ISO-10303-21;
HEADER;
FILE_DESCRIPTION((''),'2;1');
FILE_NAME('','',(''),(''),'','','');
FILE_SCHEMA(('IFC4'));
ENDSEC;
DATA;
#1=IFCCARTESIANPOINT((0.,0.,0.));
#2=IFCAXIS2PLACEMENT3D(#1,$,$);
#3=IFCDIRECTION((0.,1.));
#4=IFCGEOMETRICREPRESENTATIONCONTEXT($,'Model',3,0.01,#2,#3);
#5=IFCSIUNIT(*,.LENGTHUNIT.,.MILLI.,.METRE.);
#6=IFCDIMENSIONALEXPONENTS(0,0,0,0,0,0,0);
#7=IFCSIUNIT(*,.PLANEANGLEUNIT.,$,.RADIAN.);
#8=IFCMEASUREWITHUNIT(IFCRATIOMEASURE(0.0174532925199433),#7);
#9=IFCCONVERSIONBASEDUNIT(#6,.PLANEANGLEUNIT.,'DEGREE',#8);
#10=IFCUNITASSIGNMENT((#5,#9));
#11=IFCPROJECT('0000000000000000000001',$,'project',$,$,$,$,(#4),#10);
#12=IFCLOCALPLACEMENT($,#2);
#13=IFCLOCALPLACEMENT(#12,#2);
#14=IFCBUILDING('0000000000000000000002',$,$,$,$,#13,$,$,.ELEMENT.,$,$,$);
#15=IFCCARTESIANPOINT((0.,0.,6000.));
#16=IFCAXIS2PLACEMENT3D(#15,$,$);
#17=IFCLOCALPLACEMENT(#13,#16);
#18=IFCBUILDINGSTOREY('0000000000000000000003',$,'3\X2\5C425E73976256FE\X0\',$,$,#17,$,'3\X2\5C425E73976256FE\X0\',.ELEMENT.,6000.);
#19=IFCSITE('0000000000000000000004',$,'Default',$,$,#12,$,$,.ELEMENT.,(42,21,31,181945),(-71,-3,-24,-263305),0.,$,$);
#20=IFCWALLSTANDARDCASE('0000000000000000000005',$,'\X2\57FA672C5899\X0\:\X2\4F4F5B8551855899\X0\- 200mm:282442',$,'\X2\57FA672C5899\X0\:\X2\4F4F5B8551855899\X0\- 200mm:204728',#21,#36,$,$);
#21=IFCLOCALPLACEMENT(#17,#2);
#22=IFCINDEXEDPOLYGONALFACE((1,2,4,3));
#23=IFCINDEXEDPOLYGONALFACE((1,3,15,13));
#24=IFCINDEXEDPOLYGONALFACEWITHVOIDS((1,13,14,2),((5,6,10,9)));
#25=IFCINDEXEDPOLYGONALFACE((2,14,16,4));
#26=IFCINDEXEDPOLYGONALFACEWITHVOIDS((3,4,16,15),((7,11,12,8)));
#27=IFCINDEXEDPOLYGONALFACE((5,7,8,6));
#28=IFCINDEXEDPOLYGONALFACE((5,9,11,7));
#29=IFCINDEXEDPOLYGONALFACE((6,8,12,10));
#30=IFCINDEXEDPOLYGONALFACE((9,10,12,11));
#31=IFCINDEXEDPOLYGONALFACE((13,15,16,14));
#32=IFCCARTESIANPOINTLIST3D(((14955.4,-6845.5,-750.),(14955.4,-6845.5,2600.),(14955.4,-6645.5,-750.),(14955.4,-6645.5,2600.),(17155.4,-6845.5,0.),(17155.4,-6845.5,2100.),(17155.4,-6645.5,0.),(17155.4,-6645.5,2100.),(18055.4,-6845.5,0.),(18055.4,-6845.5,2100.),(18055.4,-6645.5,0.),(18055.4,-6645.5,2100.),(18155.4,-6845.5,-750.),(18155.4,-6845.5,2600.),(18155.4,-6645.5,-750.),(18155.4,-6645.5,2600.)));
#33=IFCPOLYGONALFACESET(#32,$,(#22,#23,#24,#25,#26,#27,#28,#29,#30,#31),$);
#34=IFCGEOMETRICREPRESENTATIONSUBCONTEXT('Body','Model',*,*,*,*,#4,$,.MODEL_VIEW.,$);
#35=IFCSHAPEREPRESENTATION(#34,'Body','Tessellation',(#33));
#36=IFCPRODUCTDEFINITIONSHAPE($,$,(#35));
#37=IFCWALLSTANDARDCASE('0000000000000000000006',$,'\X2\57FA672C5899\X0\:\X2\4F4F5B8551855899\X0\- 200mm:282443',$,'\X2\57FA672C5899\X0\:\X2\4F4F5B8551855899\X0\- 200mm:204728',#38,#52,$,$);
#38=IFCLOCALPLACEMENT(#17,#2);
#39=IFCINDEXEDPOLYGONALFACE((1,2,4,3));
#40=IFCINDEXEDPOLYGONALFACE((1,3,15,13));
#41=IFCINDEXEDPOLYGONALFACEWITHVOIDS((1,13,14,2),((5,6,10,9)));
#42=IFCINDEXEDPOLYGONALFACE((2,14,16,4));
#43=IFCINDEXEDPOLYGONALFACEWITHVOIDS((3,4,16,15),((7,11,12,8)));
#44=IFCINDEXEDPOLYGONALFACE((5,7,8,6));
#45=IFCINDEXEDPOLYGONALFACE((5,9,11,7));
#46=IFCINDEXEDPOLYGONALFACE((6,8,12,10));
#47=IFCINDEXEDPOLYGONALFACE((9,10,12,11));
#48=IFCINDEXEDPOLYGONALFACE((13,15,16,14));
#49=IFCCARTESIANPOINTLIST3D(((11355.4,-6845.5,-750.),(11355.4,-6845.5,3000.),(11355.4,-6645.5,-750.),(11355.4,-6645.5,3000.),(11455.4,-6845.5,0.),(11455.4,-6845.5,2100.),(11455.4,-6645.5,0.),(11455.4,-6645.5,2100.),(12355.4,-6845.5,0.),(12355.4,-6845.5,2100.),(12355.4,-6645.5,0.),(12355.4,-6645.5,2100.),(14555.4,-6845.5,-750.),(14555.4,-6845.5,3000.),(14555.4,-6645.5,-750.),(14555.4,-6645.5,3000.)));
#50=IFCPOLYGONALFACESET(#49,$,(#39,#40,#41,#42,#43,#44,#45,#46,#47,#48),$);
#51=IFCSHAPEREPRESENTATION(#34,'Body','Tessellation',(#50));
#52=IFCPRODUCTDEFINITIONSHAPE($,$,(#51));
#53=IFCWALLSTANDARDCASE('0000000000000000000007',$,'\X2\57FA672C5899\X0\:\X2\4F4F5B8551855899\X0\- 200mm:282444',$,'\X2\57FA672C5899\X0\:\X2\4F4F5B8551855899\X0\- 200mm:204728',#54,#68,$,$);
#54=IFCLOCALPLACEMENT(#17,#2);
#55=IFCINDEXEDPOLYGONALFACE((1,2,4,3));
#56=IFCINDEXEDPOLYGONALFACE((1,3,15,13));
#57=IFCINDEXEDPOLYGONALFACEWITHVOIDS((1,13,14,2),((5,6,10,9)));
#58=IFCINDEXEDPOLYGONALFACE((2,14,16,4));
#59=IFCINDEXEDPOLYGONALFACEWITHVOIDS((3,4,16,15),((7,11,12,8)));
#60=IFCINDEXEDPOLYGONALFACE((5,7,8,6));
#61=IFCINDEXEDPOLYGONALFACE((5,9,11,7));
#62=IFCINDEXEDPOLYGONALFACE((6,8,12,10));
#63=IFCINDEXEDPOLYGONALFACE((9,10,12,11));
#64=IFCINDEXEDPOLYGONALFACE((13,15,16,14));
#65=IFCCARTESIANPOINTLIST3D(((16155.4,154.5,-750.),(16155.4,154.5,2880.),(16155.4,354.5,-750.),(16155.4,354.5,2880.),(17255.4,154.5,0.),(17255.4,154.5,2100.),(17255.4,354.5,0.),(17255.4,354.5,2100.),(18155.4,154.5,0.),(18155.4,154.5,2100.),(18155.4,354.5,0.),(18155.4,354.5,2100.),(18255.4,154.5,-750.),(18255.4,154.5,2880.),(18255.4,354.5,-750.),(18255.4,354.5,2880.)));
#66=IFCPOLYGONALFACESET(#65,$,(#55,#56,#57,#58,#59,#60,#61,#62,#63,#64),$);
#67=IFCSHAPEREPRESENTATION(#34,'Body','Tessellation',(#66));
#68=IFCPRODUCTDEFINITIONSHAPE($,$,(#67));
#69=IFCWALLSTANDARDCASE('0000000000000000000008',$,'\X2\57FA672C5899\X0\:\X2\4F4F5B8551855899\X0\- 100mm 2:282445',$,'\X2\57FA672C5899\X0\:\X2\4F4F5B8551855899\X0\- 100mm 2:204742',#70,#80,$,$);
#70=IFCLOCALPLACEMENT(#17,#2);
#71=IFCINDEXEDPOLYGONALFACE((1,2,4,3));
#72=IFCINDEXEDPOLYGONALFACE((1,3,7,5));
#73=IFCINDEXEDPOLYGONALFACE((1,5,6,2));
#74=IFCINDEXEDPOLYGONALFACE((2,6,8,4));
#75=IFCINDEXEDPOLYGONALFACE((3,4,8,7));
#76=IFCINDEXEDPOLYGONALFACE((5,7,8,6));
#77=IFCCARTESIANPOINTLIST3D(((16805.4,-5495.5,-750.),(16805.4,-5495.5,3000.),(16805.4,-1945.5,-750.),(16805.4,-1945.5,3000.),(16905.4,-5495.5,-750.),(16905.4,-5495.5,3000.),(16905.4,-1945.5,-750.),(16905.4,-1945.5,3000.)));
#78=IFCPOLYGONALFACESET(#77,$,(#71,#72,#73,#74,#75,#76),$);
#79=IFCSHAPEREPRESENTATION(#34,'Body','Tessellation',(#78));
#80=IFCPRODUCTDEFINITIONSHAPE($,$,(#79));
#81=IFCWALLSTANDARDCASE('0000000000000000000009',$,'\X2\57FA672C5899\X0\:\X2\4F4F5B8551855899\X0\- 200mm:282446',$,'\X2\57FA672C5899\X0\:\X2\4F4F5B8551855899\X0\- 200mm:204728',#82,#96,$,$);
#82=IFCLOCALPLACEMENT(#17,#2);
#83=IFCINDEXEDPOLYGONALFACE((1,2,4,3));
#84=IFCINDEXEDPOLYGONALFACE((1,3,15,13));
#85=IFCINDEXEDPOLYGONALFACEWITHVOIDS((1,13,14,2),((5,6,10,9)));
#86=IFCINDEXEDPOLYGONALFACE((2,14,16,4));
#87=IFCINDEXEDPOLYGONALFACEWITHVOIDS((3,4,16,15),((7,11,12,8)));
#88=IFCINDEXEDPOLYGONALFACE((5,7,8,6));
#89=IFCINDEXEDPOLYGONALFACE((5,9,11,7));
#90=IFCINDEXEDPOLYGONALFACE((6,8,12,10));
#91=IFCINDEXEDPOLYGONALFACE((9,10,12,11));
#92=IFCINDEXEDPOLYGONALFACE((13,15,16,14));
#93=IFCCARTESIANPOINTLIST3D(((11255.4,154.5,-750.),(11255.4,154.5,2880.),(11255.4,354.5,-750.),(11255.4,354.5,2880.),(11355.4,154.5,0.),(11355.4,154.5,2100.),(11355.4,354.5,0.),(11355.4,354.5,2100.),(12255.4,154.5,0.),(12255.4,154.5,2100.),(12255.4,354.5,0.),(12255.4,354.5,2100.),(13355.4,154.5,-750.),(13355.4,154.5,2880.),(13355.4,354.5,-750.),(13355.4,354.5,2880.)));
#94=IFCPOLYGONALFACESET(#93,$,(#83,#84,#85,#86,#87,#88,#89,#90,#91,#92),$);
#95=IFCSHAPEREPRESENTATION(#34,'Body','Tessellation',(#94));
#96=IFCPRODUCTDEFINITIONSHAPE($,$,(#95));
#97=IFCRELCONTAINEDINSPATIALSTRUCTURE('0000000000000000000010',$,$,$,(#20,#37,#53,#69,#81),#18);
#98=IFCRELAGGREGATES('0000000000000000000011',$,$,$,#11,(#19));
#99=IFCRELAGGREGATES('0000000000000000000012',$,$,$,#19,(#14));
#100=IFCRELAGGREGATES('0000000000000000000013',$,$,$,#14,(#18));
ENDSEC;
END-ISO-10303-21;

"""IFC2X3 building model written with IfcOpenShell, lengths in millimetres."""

from ifc_helpers import new_model, entity, si_unit, converted_unit, direction, frame, frame_2d, origin, place, context, subcontext, project, spatial, polyline, rectangle, extrude, clip, bounded_halfspace, element, save


model = new_model("IFC2X3")

# Units and contexts
model_context = context("Model", 3, precision=0.01, world=origin(), true_north=direction((0.0, 1.0)))
body_context = subcontext(model_context, "Body", "Model", "MODEL_VIEW")
ifc_project = project(units=[si_unit("LENGTHUNIT", "METRE", prefix="MILLI"), converted_unit("PLANEANGLEUNIT", "DEGREE", entity("IfcRatioMeasure", 0.0174532925199433), si_unit("PLANEANGLEUNIT", "RADIAN"), dimensions=[0, 0, 0, 0, 0, 0, 0])], contexts=[model_context])

# Site, building, storey
site_placement = place(None, origin())
site = spatial("IfcSite", under=ifc_project, at=site_placement, Name="Default", CompositionType="ELEMENT", RefLatitude=(42, 21, 31, 181945), RefLongitude=(-71, -3, -24, -263305), RefElevation=0.0)
building_placement = place(site_placement, origin())
building = spatial("IfcBuilding", under=site, at=building_placement, CompositionType="ELEMENT")
storey_placement = place(building_placement, frame((0.0, 0.0, 6000.0)))
storey = spatial("IfcBuildingStorey", under=building, at=storey_placement, Name="3层平面图", LongName="3层平面图", CompositionType="ELEMENT", Elevation=6000.0)

# Walls, openings
wall_1_placement = place(storey_placement, frame((18155.4, -6745.5, -750.0), z_axis=(0.0, 0.0, 1.0), x_axis=(-1.0, 0.0, 0.0)))
wall_1 = element("IfcWallStandardCase", 1, at=wall_1_placement, inside=storey, Name="基本墙:住宅内墙- 200mm:282442", ObjectType="基本墙:住宅内墙- 200mm:204728", context=body_context, shape_type="Clipping", body=[
    clip(clip(clip(extrude(rectangle(XDim=3200.0, YDim=200.0, at=frame_2d((1600.0, 0.0), x_axis=(-1.0, 0.0))), origin(), (0.0, 0.0, 1.0), 3350.0), bounded_halfspace(frame((0.0, 100.0, 0.0), z_axis=(-1.0, 0.0, 0.0), x_axis=(0.0, 0.0, -1.0)), False, frame((0.0, 100.0, 0.0), z_axis=(-1.0, 0.0, 0.0), x_axis=(0.0, 0.0, -1.0)), polyline([(0.0, 0.0), (0.0, 200.0), (-3350.0, 200.0), (-3350.0, 0.0), (0.0, 0.0)]))), bounded_halfspace(frame((3200.0, -100.0, 0.0), z_axis=(1.0, 0.0, 0.0), x_axis=(0.0, 0.0, -1.0)), False, frame((3200.0, -100.0, 0.0), z_axis=(1.0, 0.0, 0.0), x_axis=(0.0, 0.0, -1.0)), polyline([(0.0, 0.0), (0.0, 200.0), (-3350.0, 200.0), (-3350.0, 0.0), (0.0, 0.0)]))), bounded_halfspace(frame((0.0, -100.0, 3350.0), z_axis=(0.0, 0.0, 1.0), x_axis=(-1.0, 0.0, 0.0)), False, frame((0.0, -100.0, 3350.0), z_axis=(0.0, 0.0, 1.0), x_axis=(-1.0, 0.0, 0.0)), polyline([(0.0, 0.0), (-3200.0, 0.0), (-3200.0, -200.0), (0.0, -200.0), (0.0, 0.0)]))),
])
opening_1_placement = place(wall_1_placement, origin())
element("IfcOpeningElement", 2, at=opening_1_placement, cuts=wall_1, ObjectType="Opening", context=body_context, shape_type="SweptSolid", body=[
    extrude(rectangle(XDim=2100.0, YDim=900.0, at=frame_2d((0.0, 0.0), x_axis=(1.0, 0.0))), frame((550.0, -1624.0, 1800.0), z_axis=(0.0, 1.0, 0.0), x_axis=(0.0, 0.0, 1.0)), (0.0, 0.0, 1.0), 3048.0),
])
wall_2_placement = place(storey_placement, frame((11355.4, -6745.5, -750.0)))
wall_2 = element("IfcWallStandardCase", 3, at=wall_2_placement, inside=storey, Name="基本墙:住宅内墙- 200mm:282443", ObjectType="基本墙:住宅内墙- 200mm:204728", context=body_context, shape_type="Clipping", body=[
    clip(clip(extrude(rectangle(XDim=3200.0, YDim=200.0, at=frame_2d((1600.0, 0.0), x_axis=(-1.0, 0.0))), origin(), (0.0, 0.0, 1.0), 3750.0), bounded_halfspace(frame((0.0, -100.0, 0.0), z_axis=(1.0, 0.0, 0.0), x_axis=(0.0, 0.0, -1.0)), True, frame((0.0, -100.0, 0.0), z_axis=(1.0, 0.0, 0.0), x_axis=(0.0, 0.0, -1.0)), polyline([(0.0, 0.0), (0.0, 200.0), (-3750.0, 200.0), (-3750.0, 0.0), (0.0, 0.0)]))), bounded_halfspace(frame((3200.0, -100.0, 3750.0), z_axis=(1.0, 0.0, 0.0), x_axis=(0.0, 0.0, -1.0)), False, frame((3200.0, -100.0, 3750.0), z_axis=(1.0, 0.0, 0.0), x_axis=(0.0, 0.0, -1.0)), polyline([(0.0, 0.0), (3750.0, 0.0), (3750.0, 200.0), (0.0, 200.0), (0.0, 0.0)]))),
])
opening_2_placement = place(wall_2_placement, origin())
element("IfcOpeningElement", 4, at=opening_2_placement, cuts=wall_2, ObjectType="Opening", context=body_context, shape_type="SweptSolid", body=[
    extrude(rectangle(XDim=2100.0, YDim=900.0, at=frame_2d((0.0, 0.0), x_axis=(1.0, 0.0))), frame((550.0, -1424.0, 1800.0), z_axis=(0.0, 1.0, 0.0), x_axis=(0.0, 0.0, 1.0)), (0.0, 0.0, 1.0), 3048.0),
])
wall_3_placement = place(storey_placement, frame((18255.4, 254.5, -750.0), z_axis=(0.0, 0.0, 1.0), x_axis=(-1.0, 0.0, 0.0)))
wall_3 = element("IfcWallStandardCase", 5, at=wall_3_placement, inside=storey, Name="基本墙:住宅内墙- 200mm:282444", ObjectType="基本墙:住宅内墙- 200mm:204728", context=body_context, shape_type="SweptSolid", body=[
    extrude(rectangle(XDim=2100.0, YDim=200.0, at=frame_2d((1050.0, 0.0), x_axis=(-1.0, 0.0))), origin(), (0.0, 0.0, 1.0), 3630.0),
])
opening_3_placement = place(wall_3_placement, frame((1000.0, 100.0, 750.0)))
element("IfcOpeningElement", 6, at=opening_3_placement, cuts=wall_3, ObjectType="Opening", context=body_context, shape_type="SweptSolid", body=[
    extrude(rectangle(XDim=2100.0, YDim=900.0, at=frame_2d((1050.0, 450.0), x_axis=(1.0, 0.0))), frame((0.0, 0.0, 0.0), z_axis=(0.0, -1.0, 0.0), x_axis=(0.0, 0.0, 1.0)), (0.0, 0.0, 1.0), 200.0),
])

# Wall
wall_4_placement = place(storey_placement, frame((16855.4, -1945.5, -750.0), z_axis=(0.0, 0.0, 1.0), x_axis=(0.0, -1.0, 0.0)))
element("IfcWallStandardCase", 7, at=wall_4_placement, inside=storey, Name="基本墙:住宅内墙- 100mm 2:282445", ObjectType="基本墙:住宅内墙- 100mm 2:204742", context=body_context, shape_type="SweptSolid", body=[
    extrude(rectangle(XDim=3550.0, YDim=100.0, at=frame_2d((1775.0, 0.0), x_axis=(-1.0, 0.0))), origin(), (0.0, 0.0, 1.0), 3750.0),
])

# Wall, opening
wall_5_placement = place(storey_placement, frame((11255.4, 254.5, -750.0)))
wall_5 = element("IfcWallStandardCase", 8, at=wall_5_placement, inside=storey, Name="基本墙:住宅内墙- 200mm:282446", ObjectType="基本墙:住宅内墙- 200mm:204728", context=body_context, shape_type="SweptSolid", body=[
    extrude(rectangle(XDim=2100.0, YDim=200.0, at=frame_2d((1050.0, 0.0), x_axis=(-1.0, 0.0))), origin(), (0.0, 0.0, 1.0), 3630.0),
])
opening_4_placement = place(wall_5_placement, frame((100.0, -100.0, 750.0)))
element("IfcOpeningElement", 9, at=opening_4_placement, cuts=wall_5, ObjectType="Opening", context=body_context, shape_type="SweptSolid", body=[
    extrude(rectangle(XDim=2100.0, YDim=900.0, at=frame_2d((1050.0, 450.0), x_axis=(1.0, 0.0))), frame((0.0, 0.0, 0.0), z_axis=(0.0, 1.0, 0.0), x_axis=(0.0, 0.0, 1.0)), (0.0, 0.0, 1.0), 200.0),
])

save(model, "model.ifc")
